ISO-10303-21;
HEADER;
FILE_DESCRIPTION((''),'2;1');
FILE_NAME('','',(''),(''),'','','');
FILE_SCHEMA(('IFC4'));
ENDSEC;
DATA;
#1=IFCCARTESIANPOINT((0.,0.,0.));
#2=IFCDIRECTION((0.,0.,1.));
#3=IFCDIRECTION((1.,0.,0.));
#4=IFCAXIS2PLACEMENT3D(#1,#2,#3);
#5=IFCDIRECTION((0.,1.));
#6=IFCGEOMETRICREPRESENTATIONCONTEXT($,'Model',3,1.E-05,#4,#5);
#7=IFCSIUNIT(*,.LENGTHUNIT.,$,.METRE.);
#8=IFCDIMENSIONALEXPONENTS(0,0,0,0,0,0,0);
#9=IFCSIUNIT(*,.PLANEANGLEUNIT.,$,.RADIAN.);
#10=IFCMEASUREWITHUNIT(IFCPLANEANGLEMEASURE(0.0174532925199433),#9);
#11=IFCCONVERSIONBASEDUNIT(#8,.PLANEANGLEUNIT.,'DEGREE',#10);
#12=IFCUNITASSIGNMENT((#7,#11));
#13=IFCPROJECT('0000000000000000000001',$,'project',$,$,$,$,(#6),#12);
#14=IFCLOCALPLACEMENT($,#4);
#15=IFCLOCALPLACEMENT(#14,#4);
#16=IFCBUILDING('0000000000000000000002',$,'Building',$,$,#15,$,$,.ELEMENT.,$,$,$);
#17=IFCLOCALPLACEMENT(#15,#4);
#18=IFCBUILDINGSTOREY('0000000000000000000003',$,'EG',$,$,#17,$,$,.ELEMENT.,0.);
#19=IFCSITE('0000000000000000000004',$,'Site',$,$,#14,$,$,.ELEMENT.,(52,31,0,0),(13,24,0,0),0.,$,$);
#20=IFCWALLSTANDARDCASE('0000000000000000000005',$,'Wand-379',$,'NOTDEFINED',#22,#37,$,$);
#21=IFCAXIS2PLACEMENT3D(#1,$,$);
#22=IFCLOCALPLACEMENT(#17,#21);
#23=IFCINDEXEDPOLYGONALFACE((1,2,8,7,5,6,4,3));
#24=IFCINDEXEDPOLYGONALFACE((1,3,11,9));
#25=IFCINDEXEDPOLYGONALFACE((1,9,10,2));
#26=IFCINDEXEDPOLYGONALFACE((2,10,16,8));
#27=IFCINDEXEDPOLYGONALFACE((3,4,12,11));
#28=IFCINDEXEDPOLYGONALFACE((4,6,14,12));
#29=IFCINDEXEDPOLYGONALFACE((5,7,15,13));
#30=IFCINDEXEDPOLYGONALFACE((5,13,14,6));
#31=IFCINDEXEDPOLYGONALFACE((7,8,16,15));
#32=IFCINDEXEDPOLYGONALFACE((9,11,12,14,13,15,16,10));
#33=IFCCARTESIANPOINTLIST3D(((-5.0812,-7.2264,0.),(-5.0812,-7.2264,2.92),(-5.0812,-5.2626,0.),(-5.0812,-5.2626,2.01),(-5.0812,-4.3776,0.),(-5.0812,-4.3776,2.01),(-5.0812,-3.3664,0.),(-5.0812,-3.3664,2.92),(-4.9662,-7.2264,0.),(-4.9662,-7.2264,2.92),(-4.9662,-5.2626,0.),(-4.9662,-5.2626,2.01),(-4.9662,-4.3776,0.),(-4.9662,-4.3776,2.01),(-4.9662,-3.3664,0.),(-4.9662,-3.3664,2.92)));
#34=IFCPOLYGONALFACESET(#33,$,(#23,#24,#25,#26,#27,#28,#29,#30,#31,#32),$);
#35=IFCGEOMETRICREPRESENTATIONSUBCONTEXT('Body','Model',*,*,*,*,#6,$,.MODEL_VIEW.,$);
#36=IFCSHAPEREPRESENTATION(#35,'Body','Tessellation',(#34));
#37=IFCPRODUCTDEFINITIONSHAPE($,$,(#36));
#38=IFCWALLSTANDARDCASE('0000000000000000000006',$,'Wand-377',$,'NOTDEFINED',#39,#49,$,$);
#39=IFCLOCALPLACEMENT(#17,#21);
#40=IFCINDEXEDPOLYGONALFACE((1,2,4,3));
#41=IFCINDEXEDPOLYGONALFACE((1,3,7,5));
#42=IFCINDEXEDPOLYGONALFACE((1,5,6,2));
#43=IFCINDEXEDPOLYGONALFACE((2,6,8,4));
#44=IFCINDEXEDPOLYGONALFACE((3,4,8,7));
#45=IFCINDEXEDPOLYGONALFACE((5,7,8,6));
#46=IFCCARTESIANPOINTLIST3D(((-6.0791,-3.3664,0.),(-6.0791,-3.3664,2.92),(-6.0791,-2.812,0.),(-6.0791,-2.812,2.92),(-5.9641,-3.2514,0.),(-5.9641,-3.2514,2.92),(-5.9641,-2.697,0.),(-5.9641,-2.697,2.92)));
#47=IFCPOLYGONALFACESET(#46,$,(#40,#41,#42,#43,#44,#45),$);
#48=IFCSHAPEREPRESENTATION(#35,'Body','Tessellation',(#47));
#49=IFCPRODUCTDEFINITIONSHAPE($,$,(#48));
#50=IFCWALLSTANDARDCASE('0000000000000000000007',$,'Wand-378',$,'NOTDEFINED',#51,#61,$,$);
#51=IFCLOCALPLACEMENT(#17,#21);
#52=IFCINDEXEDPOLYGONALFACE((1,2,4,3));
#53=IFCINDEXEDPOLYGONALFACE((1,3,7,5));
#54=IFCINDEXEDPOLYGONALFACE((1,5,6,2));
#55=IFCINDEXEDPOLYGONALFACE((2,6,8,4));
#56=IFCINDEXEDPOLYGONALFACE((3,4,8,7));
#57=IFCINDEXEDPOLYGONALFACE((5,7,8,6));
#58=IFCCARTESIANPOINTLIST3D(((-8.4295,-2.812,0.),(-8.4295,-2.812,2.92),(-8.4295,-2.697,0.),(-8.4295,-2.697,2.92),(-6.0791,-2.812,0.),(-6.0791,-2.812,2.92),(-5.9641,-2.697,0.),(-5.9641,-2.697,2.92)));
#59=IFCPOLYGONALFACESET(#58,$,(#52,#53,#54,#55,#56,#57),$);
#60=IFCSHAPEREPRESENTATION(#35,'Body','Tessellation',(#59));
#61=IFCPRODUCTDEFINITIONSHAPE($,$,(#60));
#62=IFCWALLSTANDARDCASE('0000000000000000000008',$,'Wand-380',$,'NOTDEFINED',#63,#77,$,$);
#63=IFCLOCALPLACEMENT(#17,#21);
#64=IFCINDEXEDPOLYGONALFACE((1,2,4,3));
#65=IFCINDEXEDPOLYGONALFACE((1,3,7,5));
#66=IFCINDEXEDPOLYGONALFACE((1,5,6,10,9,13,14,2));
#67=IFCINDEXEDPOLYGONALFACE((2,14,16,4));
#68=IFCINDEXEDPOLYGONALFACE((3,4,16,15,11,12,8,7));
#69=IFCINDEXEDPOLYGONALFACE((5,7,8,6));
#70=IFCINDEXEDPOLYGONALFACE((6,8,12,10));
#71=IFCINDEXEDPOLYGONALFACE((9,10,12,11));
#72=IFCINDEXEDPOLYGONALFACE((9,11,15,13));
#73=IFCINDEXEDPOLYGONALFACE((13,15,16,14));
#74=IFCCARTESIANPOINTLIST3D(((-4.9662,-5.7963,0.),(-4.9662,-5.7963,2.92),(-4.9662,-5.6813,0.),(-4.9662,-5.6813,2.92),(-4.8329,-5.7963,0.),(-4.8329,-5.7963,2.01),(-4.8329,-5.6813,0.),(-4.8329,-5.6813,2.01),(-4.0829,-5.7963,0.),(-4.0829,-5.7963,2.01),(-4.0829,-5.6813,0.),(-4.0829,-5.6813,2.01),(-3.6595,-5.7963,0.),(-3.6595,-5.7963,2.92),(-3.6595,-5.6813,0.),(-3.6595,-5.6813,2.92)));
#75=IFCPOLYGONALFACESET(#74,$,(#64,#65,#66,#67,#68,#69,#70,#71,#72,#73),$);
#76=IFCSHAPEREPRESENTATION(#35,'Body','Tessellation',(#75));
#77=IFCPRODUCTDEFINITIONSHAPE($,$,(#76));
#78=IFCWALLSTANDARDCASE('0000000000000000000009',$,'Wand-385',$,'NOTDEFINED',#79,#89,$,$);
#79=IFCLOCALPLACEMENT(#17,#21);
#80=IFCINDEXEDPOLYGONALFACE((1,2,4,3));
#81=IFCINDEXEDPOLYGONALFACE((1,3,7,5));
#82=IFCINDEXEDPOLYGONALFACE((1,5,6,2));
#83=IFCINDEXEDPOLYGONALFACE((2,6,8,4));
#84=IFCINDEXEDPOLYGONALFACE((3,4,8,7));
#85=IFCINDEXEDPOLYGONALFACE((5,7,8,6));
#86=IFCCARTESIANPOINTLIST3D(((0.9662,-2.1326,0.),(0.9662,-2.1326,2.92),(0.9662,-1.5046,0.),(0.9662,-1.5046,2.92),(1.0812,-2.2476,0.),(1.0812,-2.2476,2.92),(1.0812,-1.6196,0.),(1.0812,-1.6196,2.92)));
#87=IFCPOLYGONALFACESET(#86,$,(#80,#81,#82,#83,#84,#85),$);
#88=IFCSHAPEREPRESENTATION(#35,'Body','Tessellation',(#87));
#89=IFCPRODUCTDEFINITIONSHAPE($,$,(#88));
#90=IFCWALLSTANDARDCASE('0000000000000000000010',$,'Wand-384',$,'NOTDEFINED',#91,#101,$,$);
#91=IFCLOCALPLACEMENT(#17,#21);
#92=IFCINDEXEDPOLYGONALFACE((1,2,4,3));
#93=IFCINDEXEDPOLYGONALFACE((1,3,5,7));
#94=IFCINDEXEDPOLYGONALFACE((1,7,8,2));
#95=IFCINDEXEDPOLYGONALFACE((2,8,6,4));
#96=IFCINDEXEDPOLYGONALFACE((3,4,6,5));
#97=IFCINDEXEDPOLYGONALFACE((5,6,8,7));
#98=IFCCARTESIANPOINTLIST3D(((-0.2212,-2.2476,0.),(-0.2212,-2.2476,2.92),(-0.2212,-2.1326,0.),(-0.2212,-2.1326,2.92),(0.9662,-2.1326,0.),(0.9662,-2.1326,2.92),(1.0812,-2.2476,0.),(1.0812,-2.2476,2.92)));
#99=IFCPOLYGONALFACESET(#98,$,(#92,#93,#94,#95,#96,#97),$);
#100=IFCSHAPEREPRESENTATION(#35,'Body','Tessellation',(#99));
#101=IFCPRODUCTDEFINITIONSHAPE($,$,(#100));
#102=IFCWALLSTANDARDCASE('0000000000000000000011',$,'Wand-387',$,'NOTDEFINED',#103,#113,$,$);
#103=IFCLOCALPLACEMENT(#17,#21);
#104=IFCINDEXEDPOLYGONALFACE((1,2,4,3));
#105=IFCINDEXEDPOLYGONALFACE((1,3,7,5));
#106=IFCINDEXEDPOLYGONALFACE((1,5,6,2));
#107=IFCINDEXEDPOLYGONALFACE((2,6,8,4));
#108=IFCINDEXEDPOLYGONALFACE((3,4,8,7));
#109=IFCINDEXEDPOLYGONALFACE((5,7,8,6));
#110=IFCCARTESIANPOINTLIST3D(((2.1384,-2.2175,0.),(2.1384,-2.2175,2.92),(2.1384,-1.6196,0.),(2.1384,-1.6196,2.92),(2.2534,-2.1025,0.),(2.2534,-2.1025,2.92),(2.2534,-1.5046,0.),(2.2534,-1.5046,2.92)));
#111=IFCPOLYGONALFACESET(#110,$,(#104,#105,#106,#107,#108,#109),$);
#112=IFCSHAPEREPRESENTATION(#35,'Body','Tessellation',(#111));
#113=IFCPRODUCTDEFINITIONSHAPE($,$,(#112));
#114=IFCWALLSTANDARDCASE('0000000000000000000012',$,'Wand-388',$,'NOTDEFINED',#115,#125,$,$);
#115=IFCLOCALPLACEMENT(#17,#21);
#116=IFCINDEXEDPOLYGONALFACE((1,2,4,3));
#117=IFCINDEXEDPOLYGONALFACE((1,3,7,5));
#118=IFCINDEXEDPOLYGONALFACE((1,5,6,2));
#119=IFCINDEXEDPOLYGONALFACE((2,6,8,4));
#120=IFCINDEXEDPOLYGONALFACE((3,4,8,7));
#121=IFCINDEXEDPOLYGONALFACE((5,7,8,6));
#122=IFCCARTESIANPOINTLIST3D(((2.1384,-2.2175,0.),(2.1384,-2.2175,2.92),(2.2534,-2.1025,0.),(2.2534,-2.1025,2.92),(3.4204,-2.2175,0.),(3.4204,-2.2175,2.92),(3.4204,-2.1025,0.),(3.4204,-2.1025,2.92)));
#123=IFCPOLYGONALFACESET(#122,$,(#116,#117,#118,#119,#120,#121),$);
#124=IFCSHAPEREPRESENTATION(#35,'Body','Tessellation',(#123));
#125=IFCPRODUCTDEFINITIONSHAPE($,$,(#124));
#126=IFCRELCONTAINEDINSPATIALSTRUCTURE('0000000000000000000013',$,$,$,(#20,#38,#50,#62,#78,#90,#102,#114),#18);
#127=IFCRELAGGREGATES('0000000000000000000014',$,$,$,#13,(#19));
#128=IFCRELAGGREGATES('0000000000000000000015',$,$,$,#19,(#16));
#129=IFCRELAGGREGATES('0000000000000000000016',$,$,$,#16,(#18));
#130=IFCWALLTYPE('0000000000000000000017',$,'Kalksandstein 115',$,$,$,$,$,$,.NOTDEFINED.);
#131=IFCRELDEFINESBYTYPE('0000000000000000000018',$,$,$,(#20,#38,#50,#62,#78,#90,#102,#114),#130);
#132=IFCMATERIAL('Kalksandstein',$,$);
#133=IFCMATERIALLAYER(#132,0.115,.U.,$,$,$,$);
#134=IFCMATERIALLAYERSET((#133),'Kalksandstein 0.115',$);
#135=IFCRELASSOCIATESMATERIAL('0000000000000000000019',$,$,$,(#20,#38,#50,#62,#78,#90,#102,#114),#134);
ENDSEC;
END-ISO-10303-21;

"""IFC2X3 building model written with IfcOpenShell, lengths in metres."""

from ifc_helpers import new_model, entity, si_unit, converted_unit, direction, frame, origin_with_axes, origin_2d_with_axis, place, context, subcontext, project, spatial, polyline, rectangle, outline, extrude, material, layer, layer_set, layer_usage, type_object, element, save


model = new_model("IFC2X3")

# Units and contexts
model_context = context("Model", 3, precision=1e-05, world=origin_with_axes(), true_north=direction((0.0, 1.0)))
body_context = subcontext(model_context, "Body", "Model", "MODEL_VIEW")
ifc_project = project(units=[si_unit("LENGTHUNIT", "METRE"), converted_unit("PLANEANGLEUNIT", "DEGREE", entity("IfcPlaneAngleMeasure", 0.0174532925199433), si_unit("PLANEANGLEUNIT", "RADIAN"), dimensions=[0, 0, 0, 0, 0, 0, 0])], contexts=[model_context])

# Site, building, storey
site_placement = place(None, origin_with_axes())
site = spatial("IfcSite", under=ifc_project, at=site_placement, Name="Site", CompositionType="ELEMENT", RefLatitude=(52, 31, 0, 0), RefLongitude=(13, 24, 0, 0), RefElevation=0.0)
building_placement = place(site_placement, origin_with_axes())
building = spatial("IfcBuilding", under=site, at=building_placement, Name="Building", CompositionType="ELEMENT")
storey_placement = place(building_placement, origin_with_axes())
storey = spatial("IfcBuildingStorey", under=building, at=storey_placement, Name="EG", CompositionType="ELEMENT", Elevation=0.0)

# Shared definitions
ifc_material = material(Name="Kalksandstein")

# Shared definitions
ifc_layer_1 = layer(ifc_material, 0.115, ventilated="UNKNOWN")
ifc_layer_set_1 = layer_set([ifc_layer_1], Name="Kalksandstein 0.115")
wall_type_1 = type_object("IfcWallType", Name="Kalksandstein 115", PredefinedType="NOTDEFINED")

# Wall, opening
ifc_layer_usage_1 = layer_usage(ifc_layer_set_1, "AXIS2", "NEGATIVE", 0.0)
wall_1_placement = place(storey_placement, frame((-4.9662, -3.3664, 0.0), z_axis=(0.0, 0.0, 1.0), x_axis=(0.0, -1.0, 0.0)))
wall_1 = element("IfcWallStandardCase", 1, at=wall_1_placement, inside=storey, type_object=wall_type_1, material=ifc_layer_usage_1, Name="Wand-379", ObjectType="NOTDEFINED", context=body_context, shape_type="SweptSolid", body=[
    extrude(outline(polyline([(0.0, -0.115), (3.86, -0.115), (3.86, 0.0), (0.0, 0.0), (0.0, -0.115)])), origin_with_axes(), (0.0, 0.0, 1.0), 2.92),
])
opening_1_placement = place(wall_1_placement, frame((1.4538, 0.0, 0.0), z_axis=(0.0, 0.0, 1.0), x_axis=(1.0, 0.0, 0.0)))
element("IfcOpeningElement", 2, at=opening_1_placement, cuts=wall_1, context=body_context, shape_type="SweptSolid", body=[
    extrude(rectangle(XDim=0.885, YDim=2.01, at=origin_2d_with_axis()), frame((0.0, 0.115, 1.005), z_axis=(0.0, -1.0, 0.0), x_axis=(-1.0, 0.0, 0.0)), (0.0, 0.0, 1.0), 0.345),
])

# Walls
ifc_layer_usage_2 = layer_usage(ifc_layer_set_1, "AXIS2", "NEGATIVE", 0.0)
wall_2_placement = place(storey_placement, frame((-6.0791, -3.3664, 0.0), z_axis=(0.0, 0.0, 1.0), x_axis=(0.0, 1.0, 0.0)))
element("IfcWallStandardCase", 3, at=wall_2_placement, inside=storey, type_object=wall_type_1, material=ifc_layer_usage_2, Name="Wand-377", ObjectType="NOTDEFINED", context=body_context, shape_type="SweptSolid", body=[
    extrude(outline(polyline([(0.115, -0.115), (0.6694, -0.115), (0.5544, 0.0), (0.0, 0.0), (0.115, -0.115)])), origin_with_axes(), (0.0, 0.0, 1.0), 2.92),
])
ifc_layer_usage_3 = layer_usage(ifc_layer_set_1, "AXIS2", "NEGATIVE", 0.0)
wall_3_placement = place(storey_placement, frame((-6.0791, -2.812, 0.0), z_axis=(0.0, 0.0, 1.0), x_axis=(-1.0, 0.0, 0.0)))
element("IfcWallStandardCase", 4, at=wall_3_placement, inside=storey, type_object=wall_type_1, material=ifc_layer_usage_3, Name="Wand-378", ObjectType="NOTDEFINED", context=body_context, shape_type="SweptSolid", body=[
    extrude(outline(polyline([(-0.115, -0.115), (2.3504, -0.115), (2.3504, 0.0), (0.0, 0.0), (-0.115, -0.115)])), origin_with_axes(), (0.0, 0.0, 1.0), 2.92),
])

# Wall, opening
ifc_layer_usage_4 = layer_usage(ifc_layer_set_1, "AXIS2", "NEGATIVE", 0.0)
wall_4_placement = place(storey_placement, frame((-4.9662, -5.6813, 0.0), z_axis=(0.0, 0.0, 1.0), x_axis=(1.0, 0.0, 0.0)))
wall_4 = element("IfcWallStandardCase", 5, at=wall_4_placement, inside=storey, type_object=wall_type_1, material=ifc_layer_usage_4, Name="Wand-380", ObjectType="NOTDEFINED", context=body_context, shape_type="SweptSolid", body=[
    extrude(outline(polyline([(0.0, -0.115), (1.3067, -0.115), (1.3067, 0.0), (0.0, 0.0), (0.0, -0.115)])), origin_with_axes(), (0.0, 0.0, 1.0), 2.92),
])
opening_2_placement = place(wall_4_placement, frame((0.5083, 0.0, 0.0), z_axis=(0.0, 0.0, 1.0), x_axis=(1.0, 0.0, 0.0)))
element("IfcOpeningElement", 6, at=opening_2_placement, cuts=wall_4, context=body_context, shape_type="SweptSolid", body=[
    extrude(rectangle(XDim=0.75, YDim=2.01, at=origin_2d_with_axis()), frame((0.0, 0.115, 1.005), z_axis=(0.0, -1.0, 0.0), x_axis=(-1.0, 0.0, 0.0)), (0.0, 0.0, 1.0), 0.345),
])

# Walls
ifc_layer_usage_5 = layer_usage(ifc_layer_set_1, "AXIS2", "NEGATIVE", 0.0)
wall_5_placement = place(storey_placement, frame((0.9662, -2.1326, 0.0), z_axis=(0.0, 0.0, 1.0), x_axis=(0.0, 1.0, 0.0)))
element("IfcWallStandardCase", 7, at=wall_5_placement, inside=storey, type_object=wall_type_1, material=ifc_layer_usage_5, Name="Wand-385", ObjectType="NOTDEFINED", context=body_context, shape_type="SweptSolid", body=[
    extrude(outline(polyline([(-0.115, -0.115), (0.513, -0.115), (0.628, 0.0), (0.0, 0.0), (-0.115, -0.115)])), origin_with_axes(), (0.0, 0.0, 1.0), 2.92),
])
ifc_layer_usage_6 = layer_usage(ifc_layer_set_1, "AXIS2", "NEGATIVE", 0.0)
wall_6_placement = place(storey_placement, frame((-0.2212, -2.1326, 0.0), z_axis=(0.0, 0.0, 1.0), x_axis=(1.0, 0.0, 0.0)))
element("IfcWallStandardCase", 8, at=wall_6_placement, inside=storey, type_object=wall_type_1, material=ifc_layer_usage_6, Name="Wand-384", ObjectType="NOTDEFINED", context=body_context, shape_type="SweptSolid", body=[
    extrude(outline(polyline([(0.0, -0.115), (1.3024, -0.115), (1.1874, 0.0), (0.0, 0.0), (0.0, -0.115)])), origin_with_axes(), (0.0, 0.0, 1.0), 2.92),
])
ifc_layer_usage_7 = layer_usage(ifc_layer_set_1, "AXIS2", "NEGATIVE", 0.0)
wall_7_placement = place(storey_placement, frame((2.2534, -1.5046, 0.0), z_axis=(0.0, 0.0, 1.0), x_axis=(0.0, -1.0, 0.0)))
element("IfcWallStandardCase", 9, at=wall_7_placement, inside=storey, type_object=wall_type_1, material=ifc_layer_usage_7, Name="Wand-387", ObjectType="NOTDEFINED", context=body_context, shape_type="SweptSolid", body=[
    extrude(outline(polyline([(0.115, -0.115), (0.7129, -0.115), (0.5979, 0.0), (0.0, 0.0), (0.115, -0.115)])), origin_with_axes(), (0.0, 0.0, 1.0), 2.92),
])
ifc_layer_usage_8 = layer_usage(ifc_layer_set_1, "AXIS2", "NEGATIVE", 0.0)
wall_8_placement = place(storey_placement, frame((2.2534, -2.1025, 0.0), z_axis=(0.0, 0.0, 1.0), x_axis=(1.0, 0.0, 0.0)))
element("IfcWallStandardCase", 10, at=wall_8_placement, inside=storey, type_object=wall_type_1, material=ifc_layer_usage_8, Name="Wand-388", ObjectType="NOTDEFINED", context=body_context, shape_type="SweptSolid", body=[
    extrude(outline(polyline([(-0.115, -0.115), (1.167, -0.115), (1.167, 0.0), (0.0, 0.0), (-0.115, -0.115)])), origin_with_axes(), (0.0, 0.0, 1.0), 2.92),
])

save(model, "model.ifc")
